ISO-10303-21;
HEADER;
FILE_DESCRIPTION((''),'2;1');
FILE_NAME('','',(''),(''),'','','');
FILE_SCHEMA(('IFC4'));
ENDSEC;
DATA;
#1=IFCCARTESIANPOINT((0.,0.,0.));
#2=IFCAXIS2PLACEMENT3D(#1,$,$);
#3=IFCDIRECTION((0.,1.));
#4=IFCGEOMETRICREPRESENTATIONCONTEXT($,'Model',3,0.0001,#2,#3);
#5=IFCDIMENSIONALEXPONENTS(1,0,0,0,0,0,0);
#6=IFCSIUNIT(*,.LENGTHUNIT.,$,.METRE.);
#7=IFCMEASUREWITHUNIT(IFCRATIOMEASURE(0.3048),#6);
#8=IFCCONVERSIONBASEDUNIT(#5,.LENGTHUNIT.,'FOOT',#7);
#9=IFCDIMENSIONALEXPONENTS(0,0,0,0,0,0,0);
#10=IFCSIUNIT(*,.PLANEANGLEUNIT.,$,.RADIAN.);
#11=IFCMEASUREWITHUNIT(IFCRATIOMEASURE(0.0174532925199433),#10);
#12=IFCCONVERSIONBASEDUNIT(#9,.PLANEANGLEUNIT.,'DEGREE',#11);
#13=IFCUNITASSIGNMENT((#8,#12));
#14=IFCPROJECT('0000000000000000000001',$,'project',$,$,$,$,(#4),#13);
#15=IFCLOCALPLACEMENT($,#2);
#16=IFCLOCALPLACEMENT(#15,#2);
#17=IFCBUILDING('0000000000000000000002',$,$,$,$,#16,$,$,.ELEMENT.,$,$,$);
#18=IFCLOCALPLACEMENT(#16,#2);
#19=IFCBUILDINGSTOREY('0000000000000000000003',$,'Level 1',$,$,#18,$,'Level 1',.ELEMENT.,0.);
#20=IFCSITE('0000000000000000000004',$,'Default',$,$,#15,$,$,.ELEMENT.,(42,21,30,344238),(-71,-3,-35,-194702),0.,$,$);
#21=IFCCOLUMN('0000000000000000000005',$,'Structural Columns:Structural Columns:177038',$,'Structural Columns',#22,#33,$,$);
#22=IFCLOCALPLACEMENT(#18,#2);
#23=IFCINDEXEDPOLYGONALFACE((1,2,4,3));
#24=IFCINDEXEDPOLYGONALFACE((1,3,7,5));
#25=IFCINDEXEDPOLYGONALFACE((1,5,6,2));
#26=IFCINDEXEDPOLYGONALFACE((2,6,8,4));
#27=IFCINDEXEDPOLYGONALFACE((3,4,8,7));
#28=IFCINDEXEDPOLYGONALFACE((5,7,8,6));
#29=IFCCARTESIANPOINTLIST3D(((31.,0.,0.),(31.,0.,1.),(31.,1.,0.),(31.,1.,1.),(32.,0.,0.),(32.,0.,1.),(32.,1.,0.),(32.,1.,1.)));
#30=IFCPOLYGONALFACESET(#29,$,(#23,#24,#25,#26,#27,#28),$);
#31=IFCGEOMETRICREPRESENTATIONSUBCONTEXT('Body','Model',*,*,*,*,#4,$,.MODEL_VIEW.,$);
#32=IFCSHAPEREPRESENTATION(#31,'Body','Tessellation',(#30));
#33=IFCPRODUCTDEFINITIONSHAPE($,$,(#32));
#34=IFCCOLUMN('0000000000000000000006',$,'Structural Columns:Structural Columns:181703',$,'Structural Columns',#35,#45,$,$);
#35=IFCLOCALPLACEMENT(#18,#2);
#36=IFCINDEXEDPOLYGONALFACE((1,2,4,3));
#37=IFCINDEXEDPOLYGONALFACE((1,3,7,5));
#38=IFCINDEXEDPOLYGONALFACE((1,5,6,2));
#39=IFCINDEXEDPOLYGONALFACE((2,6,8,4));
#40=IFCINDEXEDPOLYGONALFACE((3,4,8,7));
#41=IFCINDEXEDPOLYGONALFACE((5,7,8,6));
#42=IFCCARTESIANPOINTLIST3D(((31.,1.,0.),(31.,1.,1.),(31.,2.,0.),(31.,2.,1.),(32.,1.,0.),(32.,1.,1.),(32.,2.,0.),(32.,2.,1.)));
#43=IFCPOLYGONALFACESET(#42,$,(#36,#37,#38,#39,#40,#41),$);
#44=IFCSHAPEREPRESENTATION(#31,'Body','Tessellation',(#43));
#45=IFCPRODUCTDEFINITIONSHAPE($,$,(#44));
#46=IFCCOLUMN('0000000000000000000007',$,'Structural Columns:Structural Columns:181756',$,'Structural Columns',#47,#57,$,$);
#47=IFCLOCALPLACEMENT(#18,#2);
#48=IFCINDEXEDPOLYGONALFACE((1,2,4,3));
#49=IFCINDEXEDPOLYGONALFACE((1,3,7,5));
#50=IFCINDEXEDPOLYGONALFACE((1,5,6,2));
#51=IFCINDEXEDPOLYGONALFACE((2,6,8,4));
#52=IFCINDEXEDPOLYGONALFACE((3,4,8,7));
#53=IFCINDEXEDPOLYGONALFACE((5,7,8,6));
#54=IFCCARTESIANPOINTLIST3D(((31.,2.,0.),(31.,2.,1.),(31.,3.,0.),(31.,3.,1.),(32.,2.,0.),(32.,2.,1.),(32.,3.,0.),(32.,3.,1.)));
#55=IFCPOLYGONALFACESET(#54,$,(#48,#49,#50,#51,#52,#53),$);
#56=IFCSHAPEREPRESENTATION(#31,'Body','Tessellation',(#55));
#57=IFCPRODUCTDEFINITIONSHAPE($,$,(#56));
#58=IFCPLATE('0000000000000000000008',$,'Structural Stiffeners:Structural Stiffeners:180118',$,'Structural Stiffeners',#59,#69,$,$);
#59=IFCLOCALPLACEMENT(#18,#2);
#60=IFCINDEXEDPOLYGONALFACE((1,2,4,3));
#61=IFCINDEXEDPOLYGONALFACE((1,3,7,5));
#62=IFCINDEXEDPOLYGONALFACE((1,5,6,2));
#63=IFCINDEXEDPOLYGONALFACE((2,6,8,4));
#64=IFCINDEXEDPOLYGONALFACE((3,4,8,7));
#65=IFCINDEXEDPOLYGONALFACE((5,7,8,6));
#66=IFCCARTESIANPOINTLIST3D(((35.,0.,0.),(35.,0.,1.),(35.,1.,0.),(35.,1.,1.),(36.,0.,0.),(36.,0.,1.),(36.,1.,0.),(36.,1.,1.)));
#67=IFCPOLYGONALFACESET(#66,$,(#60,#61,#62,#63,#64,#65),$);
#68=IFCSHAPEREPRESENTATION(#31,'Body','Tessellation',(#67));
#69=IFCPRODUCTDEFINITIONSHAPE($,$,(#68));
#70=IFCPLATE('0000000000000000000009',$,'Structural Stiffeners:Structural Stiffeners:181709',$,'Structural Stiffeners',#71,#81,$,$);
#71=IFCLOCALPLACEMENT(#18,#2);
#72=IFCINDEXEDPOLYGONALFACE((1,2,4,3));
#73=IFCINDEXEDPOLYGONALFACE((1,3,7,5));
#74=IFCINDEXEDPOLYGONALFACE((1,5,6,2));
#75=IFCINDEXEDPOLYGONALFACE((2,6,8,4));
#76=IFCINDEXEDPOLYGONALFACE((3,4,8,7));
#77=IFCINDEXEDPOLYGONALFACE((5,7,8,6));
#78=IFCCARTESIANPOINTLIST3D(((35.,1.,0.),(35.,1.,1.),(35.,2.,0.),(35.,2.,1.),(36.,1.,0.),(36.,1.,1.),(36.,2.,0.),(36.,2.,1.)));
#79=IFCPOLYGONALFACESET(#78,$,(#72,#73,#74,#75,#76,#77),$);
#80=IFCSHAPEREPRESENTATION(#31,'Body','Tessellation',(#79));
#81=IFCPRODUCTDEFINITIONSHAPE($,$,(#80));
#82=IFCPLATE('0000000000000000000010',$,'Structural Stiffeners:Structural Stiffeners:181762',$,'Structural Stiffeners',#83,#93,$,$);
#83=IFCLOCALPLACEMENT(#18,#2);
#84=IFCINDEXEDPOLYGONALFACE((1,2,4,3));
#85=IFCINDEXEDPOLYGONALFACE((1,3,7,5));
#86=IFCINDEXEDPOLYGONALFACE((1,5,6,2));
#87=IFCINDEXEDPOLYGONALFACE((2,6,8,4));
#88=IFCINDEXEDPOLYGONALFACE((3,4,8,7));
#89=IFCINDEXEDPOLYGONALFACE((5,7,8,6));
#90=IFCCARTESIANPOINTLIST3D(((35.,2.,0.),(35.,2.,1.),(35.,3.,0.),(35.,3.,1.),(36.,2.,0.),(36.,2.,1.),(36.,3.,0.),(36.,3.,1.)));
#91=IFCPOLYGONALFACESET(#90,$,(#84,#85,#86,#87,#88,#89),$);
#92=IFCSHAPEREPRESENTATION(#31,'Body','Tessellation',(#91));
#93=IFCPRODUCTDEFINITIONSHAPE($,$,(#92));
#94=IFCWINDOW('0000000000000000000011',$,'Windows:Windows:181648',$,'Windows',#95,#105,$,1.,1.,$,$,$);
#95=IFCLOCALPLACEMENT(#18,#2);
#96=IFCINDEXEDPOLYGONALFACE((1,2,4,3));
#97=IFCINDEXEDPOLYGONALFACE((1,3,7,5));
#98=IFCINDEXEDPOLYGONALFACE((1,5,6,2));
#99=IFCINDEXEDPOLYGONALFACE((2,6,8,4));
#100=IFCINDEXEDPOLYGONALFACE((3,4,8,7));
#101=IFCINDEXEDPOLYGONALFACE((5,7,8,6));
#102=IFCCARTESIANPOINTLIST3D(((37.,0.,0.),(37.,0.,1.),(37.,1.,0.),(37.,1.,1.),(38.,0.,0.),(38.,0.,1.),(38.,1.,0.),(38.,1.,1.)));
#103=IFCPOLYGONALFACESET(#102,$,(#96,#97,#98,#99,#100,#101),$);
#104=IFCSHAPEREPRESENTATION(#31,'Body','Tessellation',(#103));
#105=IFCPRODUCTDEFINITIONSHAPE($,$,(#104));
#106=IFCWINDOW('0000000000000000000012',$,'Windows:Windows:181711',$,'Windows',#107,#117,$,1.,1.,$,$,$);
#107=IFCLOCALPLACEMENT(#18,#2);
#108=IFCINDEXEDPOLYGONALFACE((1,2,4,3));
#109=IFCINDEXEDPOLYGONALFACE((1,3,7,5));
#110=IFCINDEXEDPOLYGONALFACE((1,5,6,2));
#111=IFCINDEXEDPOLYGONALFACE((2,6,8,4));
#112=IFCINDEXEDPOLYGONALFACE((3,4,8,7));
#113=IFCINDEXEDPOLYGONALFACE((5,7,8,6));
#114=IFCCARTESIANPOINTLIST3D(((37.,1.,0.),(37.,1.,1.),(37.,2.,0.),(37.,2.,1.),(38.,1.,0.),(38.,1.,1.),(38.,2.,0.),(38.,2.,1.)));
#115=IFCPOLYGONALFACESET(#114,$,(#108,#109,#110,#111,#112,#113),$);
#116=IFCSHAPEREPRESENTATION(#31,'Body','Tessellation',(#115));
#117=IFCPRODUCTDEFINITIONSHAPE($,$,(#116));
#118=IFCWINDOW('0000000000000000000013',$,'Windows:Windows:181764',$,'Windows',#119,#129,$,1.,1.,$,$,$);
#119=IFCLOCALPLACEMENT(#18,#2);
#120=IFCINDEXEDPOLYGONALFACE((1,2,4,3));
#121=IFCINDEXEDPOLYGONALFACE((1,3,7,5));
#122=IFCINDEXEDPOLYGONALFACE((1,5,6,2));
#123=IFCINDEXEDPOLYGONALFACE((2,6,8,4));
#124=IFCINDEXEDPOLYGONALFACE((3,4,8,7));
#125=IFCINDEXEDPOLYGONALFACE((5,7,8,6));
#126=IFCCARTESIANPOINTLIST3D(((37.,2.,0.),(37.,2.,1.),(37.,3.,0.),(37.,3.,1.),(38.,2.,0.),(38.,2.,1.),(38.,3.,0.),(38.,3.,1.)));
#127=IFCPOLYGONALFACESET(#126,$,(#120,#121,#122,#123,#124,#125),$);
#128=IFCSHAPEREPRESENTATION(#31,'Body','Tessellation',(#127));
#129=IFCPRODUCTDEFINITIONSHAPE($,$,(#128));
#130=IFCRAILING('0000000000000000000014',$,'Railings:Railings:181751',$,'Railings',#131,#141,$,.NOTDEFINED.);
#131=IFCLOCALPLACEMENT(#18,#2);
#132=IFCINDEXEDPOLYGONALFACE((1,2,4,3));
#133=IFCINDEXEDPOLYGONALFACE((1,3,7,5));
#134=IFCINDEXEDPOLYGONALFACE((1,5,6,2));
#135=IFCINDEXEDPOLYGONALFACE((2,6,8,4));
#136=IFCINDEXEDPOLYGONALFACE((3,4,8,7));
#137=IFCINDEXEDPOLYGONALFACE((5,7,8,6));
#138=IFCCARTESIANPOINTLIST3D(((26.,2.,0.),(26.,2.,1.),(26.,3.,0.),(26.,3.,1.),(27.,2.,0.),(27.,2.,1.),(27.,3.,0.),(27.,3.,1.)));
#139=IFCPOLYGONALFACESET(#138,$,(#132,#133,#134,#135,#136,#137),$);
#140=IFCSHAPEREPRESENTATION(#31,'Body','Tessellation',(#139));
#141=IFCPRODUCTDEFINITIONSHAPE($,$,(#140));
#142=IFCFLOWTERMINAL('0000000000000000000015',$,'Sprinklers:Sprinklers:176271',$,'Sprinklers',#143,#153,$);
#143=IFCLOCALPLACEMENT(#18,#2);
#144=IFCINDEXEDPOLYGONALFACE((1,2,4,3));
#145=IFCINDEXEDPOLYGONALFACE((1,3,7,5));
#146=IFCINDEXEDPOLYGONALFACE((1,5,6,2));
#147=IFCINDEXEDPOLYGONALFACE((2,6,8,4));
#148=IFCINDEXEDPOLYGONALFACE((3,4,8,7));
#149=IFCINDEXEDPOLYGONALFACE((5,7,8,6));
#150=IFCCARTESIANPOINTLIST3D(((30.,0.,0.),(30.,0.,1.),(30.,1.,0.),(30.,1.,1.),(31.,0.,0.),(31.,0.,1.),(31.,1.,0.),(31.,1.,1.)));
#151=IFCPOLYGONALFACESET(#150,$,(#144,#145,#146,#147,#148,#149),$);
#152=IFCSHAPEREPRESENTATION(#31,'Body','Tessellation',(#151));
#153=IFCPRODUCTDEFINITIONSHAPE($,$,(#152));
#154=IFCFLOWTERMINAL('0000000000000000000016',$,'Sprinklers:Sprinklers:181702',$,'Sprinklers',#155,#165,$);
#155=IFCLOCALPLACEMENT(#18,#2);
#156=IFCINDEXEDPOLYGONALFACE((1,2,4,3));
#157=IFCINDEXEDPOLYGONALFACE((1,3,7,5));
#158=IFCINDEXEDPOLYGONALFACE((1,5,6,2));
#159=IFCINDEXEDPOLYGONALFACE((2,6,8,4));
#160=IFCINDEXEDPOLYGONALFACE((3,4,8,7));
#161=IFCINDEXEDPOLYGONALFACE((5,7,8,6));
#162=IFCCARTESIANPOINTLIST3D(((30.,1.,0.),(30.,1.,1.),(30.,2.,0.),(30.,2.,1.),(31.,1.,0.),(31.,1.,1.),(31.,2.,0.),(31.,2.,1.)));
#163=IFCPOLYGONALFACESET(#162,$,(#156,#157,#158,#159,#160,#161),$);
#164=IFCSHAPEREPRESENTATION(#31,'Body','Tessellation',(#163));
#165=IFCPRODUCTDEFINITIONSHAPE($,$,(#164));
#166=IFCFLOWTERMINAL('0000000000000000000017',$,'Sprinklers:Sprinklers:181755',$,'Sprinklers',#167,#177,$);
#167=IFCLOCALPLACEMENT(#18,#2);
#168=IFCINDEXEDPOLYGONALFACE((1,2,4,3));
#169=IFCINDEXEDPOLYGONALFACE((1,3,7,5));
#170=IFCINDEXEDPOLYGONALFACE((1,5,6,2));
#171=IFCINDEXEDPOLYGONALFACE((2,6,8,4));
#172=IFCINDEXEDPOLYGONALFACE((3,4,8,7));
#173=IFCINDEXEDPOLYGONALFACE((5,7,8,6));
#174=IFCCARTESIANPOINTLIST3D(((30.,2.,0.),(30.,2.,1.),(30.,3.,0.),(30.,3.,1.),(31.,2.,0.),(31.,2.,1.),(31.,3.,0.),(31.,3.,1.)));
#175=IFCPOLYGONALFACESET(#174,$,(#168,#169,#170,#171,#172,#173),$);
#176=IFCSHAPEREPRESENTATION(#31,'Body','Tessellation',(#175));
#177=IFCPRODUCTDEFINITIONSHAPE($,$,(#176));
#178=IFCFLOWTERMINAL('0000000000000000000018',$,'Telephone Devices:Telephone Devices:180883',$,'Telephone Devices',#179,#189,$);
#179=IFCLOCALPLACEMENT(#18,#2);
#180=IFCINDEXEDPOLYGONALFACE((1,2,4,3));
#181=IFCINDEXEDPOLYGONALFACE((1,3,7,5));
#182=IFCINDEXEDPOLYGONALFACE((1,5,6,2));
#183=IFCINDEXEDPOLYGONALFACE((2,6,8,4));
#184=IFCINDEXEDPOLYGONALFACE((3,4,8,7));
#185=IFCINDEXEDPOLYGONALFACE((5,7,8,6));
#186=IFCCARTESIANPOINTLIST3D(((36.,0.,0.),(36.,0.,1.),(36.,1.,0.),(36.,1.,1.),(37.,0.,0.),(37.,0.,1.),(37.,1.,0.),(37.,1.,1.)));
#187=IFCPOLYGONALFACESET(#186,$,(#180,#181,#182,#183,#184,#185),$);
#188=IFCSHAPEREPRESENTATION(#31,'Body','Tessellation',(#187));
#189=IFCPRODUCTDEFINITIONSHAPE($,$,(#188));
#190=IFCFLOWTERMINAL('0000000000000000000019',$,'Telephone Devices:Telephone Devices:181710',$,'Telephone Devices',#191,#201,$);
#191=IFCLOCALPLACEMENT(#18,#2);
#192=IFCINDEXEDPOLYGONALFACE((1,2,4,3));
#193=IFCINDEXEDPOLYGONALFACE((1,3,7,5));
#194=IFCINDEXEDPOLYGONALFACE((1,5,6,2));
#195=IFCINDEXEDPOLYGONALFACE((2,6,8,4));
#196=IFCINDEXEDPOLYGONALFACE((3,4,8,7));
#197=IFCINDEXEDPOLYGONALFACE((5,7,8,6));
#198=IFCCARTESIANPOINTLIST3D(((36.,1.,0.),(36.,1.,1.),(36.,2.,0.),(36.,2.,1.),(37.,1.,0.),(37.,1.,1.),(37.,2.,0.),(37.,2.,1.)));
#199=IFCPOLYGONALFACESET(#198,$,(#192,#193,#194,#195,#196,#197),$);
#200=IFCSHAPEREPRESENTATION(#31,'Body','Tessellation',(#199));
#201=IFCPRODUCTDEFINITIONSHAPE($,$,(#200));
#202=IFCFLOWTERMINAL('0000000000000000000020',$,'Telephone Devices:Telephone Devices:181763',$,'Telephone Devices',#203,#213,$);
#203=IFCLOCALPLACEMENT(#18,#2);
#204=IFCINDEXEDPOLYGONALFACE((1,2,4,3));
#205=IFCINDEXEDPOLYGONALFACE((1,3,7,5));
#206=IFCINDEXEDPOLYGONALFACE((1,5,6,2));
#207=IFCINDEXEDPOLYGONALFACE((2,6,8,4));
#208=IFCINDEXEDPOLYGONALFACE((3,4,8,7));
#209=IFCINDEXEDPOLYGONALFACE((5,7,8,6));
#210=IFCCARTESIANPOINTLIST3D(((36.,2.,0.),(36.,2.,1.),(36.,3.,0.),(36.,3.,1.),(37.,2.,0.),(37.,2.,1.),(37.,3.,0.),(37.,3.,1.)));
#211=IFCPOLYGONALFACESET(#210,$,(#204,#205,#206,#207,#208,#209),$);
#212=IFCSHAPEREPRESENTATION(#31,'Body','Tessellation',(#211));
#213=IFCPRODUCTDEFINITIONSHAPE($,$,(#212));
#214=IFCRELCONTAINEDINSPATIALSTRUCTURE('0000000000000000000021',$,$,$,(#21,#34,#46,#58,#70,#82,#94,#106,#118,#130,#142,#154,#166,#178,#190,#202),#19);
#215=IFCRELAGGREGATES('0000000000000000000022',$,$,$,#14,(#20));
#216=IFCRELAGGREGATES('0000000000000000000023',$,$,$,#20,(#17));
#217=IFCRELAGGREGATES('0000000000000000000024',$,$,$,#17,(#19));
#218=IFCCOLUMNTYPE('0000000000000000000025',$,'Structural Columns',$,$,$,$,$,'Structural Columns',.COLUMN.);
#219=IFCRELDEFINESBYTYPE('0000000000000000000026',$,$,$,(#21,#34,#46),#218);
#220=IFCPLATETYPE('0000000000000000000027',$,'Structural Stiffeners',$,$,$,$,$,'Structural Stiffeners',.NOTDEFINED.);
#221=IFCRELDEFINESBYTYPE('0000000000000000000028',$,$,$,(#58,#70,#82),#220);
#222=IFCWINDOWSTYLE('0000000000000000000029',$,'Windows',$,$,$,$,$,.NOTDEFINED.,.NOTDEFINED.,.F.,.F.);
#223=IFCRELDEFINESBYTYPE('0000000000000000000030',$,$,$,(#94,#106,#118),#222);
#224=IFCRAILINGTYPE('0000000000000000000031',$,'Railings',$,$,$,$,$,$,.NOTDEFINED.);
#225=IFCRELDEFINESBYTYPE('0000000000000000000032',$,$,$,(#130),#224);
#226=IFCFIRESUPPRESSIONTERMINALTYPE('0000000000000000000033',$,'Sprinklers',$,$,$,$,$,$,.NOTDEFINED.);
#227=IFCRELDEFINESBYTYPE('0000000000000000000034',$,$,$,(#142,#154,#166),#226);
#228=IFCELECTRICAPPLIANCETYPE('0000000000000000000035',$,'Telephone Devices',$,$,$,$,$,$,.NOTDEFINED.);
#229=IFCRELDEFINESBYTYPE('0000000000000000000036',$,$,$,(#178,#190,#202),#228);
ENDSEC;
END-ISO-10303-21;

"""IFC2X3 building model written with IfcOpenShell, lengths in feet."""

from ifc_helpers import new_model, entity, si_unit, converted_unit, direction, frame, frame_2d, origin, place, context, subcontext, project, spatial, rectangle, extrude, source, transform, mapped, type_object, type_shapes, element, save


model = new_model("IFC2X3")

# Units and contexts
model_context = context("Model", 3, precision=0.0001, world=origin(), true_north=direction((0.0, 1.0)))
body_context = subcontext(model_context, "Body", "Model", "MODEL_VIEW")
ifc_project = project(units=[converted_unit("LENGTHUNIT", "FOOT", entity("IfcRatioMeasure", 0.3048), si_unit("LENGTHUNIT", "METRE"), dimensions=[1, 0, 0, 0, 0, 0, 0]), converted_unit("PLANEANGLEUNIT", "DEGREE", entity("IfcRatioMeasure", 0.0174532925199433), si_unit("PLANEANGLEUNIT", "RADIAN"), dimensions=[0, 0, 0, 0, 0, 0, 0])], contexts=[model_context])

# Site, building, storey
site_placement = place(None, origin())
site = spatial("IfcSite", under=ifc_project, at=site_placement, Name="Default", CompositionType="ELEMENT", RefLatitude=(42, 21, 30, 344238), RefLongitude=(-71, -3, -35, -194702), RefElevation=0.0)
building_placement = place(site_placement, origin())
building = spatial("IfcBuilding", under=site, at=building_placement, CompositionType="ELEMENT")
storey_placement = place(building_placement, origin())
storey = spatial("IfcBuildingStorey", under=building, at=storey_placement, Name="Level 1", LongName="Level 1", CompositionType="ELEMENT", Elevation=0.0)

# Columns
column_type = type_object("IfcColumnType", Name="Structural Columns", ElementType="Structural Columns", PredefinedType="COLUMN")
shared_shape_1 = source(origin(), body_context, "Body", "SweptSolid", [
    extrude(rectangle(XDim=1.0, YDim=1.0, at=frame_2d((0.0, 0.0), x_axis=(1.0, 0.0))), frame((0.5, 0.5, 0.0), z_axis=(0.0, 0.0, 1.0), x_axis=(0.0, -1.0, 0.0)), (0.0, 0.0, 1.0), 1.0),
])
type_shapes(column_type, [shared_shape_1])
for number, where, name in (
    (1, (31.0, 0.0, 0.0), "Structural Columns:Structural Columns:177038"),
    (2, (31.0, 1.0, 0.0), "Structural Columns:Structural Columns:181703"),
    (3, (31.0, 2.0, 0.0), "Structural Columns:Structural Columns:181756"),
):
    element("IfcColumn", number, at=place(storey_placement, frame(where)), inside=storey, type_object=column_type, Name=name, ObjectType="Structural Columns", context=body_context, shape_type="MappedRepresentation", body=[
        mapped(shared_shape_1, transform((0.0, 0.0, 0.0), scale=1.0)),
    ])

# Plates
plate_type = type_object("IfcPlateType", Name="Structural Stiffeners", ElementType="Structural Stiffeners", PredefinedType="NOTDEFINED")
shared_shape_2 = source(origin(), body_context, "Body", "SweptSolid", [
    extrude(rectangle(XDim=1.0, YDim=1.0, at=frame_2d((0.0, 0.0), x_axis=(1.0, 0.0))), frame((0.5, 0.5, 0.0), z_axis=(0.0, 0.0, 1.0), x_axis=(0.0, 1.0, 0.0)), (0.0, 0.0, 1.0), 1.0),
])
type_shapes(plate_type, [shared_shape_2])
for number, where, name in (
    (4, (35.0, 0.0, 0.0), "Structural Stiffeners:Structural Stiffeners:180118"),
    (5, (35.0, 1.0, 0.0), "Structural Stiffeners:Structural Stiffeners:181709"),
    (6, (35.0, 2.0, 0.0), "Structural Stiffeners:Structural Stiffeners:181762"),
):
    element("IfcPlate", number, at=place(storey_placement, frame(where)), inside=storey, type_object=plate_type, Name=name, ObjectType="Structural Stiffeners", context=body_context, shape_type="MappedRepresentation", body=[
        mapped(shared_shape_2, transform((0.0, 0.0, 0.0), scale=1.0)),
    ])

# Windows
window_style = type_object("IfcWindowStyle", Name="Windows", ConstructionType="NOTDEFINED", OperationType="NOTDEFINED", ParameterTakesPrecedence=False, Sizeable=False)
shared_shape_3 = source(origin(), body_context, "Body", "SweptSolid", [
    extrude(rectangle(XDim=1.0, YDim=1.0, at=frame_2d((0.0, 0.0), x_axis=(1.0, 0.0))), frame((0.5, 0.5, 0.0), z_axis=(0.0, 0.0, 1.0), x_axis=(0.0, 1.0, 0.0)), (0.0, 0.0, 1.0), 1.0),
])
type_shapes(window_style, [shared_shape_3])
for number, where, name in (
    (7, (37.0, 0.0, 0.0), "Windows:Windows:181648"),
    (8, (37.0, 1.0, 0.0), "Windows:Windows:181711"),
    (9, (37.0, 2.0, 0.0), "Windows:Windows:181764"),
):
    element("IfcWindow", number, at=place(storey_placement, frame(where)), inside=storey, type_object=window_style, Name=name, ObjectType="Windows", OverallHeight=1.0, OverallWidth=1.0, context=body_context, shape_type="MappedRepresentation", body=[
        mapped(shared_shape_3, transform((0.0, 0.0, 0.0), scale=1.0)),
    ])

# Railing
railing_type = type_object("IfcRailingType", Name="Railings", PredefinedType="NOTDEFINED")
shared_shape_4 = source(origin(), body_context, "Body", "SweptSolid", [
    extrude(rectangle(XDim=1.0, YDim=1.0, at=frame_2d((0.0, 0.0), x_axis=(1.0, 0.0))), frame((0.5, 0.5, 0.0), z_axis=(0.0, 0.0, 1.0), x_axis=(0.0, 1.0, 0.0)), (0.0, 0.0, 1.0), 1.0),
])
type_shapes(railing_type, [shared_shape_4])
railing_placement = place(storey_placement, frame((26.0, 2.0, 0.0)))
element("IfcRailing", 10, at=railing_placement, inside=storey, type_object=railing_type, Name="Railings:Railings:181751", ObjectType="Railings", PredefinedType="NOTDEFINED", context=body_context, shape_type="MappedRepresentation", body=[
    mapped(shared_shape_4, transform((0.0, 0.0, 0.0), scale=1.0)),
])

# Flow terminals
fire_suppression_terminal_type = type_object("IfcFireSuppressionTerminalType", Name="Sprinklers", PredefinedType="NOTDEFINED")
shared_shape_5 = source(origin(), body_context, "Body", "SweptSolid", [
    extrude(rectangle(XDim=1.0, YDim=1.0, at=frame_2d((0.0, 0.0), x_axis=(1.0, 0.0))), frame((0.5, 0.5, 0.0), z_axis=(0.0, 0.0, 1.0), x_axis=(0.0, 1.0, 0.0)), (0.0, 0.0, 1.0), 1.0),
])
type_shapes(fire_suppression_terminal_type, [shared_shape_5])
for number, where, name in (
    (11, (30.0, 0.0, 0.0), "Sprinklers:Sprinklers:176271"),
    (12, (30.0, 1.0, 0.0), "Sprinklers:Sprinklers:181702"),
    (13, (30.0, 2.0, 0.0), "Sprinklers:Sprinklers:181755"),
):
    element("IfcFlowTerminal", number, at=place(storey_placement, frame(where)), inside=storey, type_object=fire_suppression_terminal_type, Name=name, ObjectType="Sprinklers", context=body_context, shape_type="MappedRepresentation", body=[
        mapped(shared_shape_5, transform((0.0, 0.0, 0.0), scale=1.0)),
    ])
electric_appliance_type = type_object("IfcElectricApplianceType", Name="Telephone Devices", PredefinedType="TELEPHONE")
shared_shape_6 = source(origin(), body_context, "Body", "SweptSolid", [
    extrude(rectangle(XDim=1.0, YDim=1.0, at=frame_2d((0.0, 0.0), x_axis=(1.0, 0.0))), frame((0.5, 0.5, 0.0), z_axis=(0.0, 0.0, 1.0), x_axis=(0.0, 1.0, 0.0)), (0.0, 0.0, 1.0), 1.0),
])
type_shapes(electric_appliance_type, [shared_shape_6])
for number, where, name in (
    (14, (36.0, 0.0, 0.0), "Telephone Devices:Telephone Devices:180883"),
    (15, (36.0, 1.0, 0.0), "Telephone Devices:Telephone Devices:181710"),
    (16, (36.0, 2.0, 0.0), "Telephone Devices:Telephone Devices:181763"),
):
    element("IfcFlowTerminal", number, at=place(storey_placement, frame(where)), inside=storey, type_object=electric_appliance_type, Name=name, ObjectType="Telephone Devices", context=body_context, shape_type="MappedRepresentation", body=[
        mapped(shared_shape_6, transform((0.0, 0.0, 0.0), scale=1.0)),
    ])

save(model, "model.ifc")
